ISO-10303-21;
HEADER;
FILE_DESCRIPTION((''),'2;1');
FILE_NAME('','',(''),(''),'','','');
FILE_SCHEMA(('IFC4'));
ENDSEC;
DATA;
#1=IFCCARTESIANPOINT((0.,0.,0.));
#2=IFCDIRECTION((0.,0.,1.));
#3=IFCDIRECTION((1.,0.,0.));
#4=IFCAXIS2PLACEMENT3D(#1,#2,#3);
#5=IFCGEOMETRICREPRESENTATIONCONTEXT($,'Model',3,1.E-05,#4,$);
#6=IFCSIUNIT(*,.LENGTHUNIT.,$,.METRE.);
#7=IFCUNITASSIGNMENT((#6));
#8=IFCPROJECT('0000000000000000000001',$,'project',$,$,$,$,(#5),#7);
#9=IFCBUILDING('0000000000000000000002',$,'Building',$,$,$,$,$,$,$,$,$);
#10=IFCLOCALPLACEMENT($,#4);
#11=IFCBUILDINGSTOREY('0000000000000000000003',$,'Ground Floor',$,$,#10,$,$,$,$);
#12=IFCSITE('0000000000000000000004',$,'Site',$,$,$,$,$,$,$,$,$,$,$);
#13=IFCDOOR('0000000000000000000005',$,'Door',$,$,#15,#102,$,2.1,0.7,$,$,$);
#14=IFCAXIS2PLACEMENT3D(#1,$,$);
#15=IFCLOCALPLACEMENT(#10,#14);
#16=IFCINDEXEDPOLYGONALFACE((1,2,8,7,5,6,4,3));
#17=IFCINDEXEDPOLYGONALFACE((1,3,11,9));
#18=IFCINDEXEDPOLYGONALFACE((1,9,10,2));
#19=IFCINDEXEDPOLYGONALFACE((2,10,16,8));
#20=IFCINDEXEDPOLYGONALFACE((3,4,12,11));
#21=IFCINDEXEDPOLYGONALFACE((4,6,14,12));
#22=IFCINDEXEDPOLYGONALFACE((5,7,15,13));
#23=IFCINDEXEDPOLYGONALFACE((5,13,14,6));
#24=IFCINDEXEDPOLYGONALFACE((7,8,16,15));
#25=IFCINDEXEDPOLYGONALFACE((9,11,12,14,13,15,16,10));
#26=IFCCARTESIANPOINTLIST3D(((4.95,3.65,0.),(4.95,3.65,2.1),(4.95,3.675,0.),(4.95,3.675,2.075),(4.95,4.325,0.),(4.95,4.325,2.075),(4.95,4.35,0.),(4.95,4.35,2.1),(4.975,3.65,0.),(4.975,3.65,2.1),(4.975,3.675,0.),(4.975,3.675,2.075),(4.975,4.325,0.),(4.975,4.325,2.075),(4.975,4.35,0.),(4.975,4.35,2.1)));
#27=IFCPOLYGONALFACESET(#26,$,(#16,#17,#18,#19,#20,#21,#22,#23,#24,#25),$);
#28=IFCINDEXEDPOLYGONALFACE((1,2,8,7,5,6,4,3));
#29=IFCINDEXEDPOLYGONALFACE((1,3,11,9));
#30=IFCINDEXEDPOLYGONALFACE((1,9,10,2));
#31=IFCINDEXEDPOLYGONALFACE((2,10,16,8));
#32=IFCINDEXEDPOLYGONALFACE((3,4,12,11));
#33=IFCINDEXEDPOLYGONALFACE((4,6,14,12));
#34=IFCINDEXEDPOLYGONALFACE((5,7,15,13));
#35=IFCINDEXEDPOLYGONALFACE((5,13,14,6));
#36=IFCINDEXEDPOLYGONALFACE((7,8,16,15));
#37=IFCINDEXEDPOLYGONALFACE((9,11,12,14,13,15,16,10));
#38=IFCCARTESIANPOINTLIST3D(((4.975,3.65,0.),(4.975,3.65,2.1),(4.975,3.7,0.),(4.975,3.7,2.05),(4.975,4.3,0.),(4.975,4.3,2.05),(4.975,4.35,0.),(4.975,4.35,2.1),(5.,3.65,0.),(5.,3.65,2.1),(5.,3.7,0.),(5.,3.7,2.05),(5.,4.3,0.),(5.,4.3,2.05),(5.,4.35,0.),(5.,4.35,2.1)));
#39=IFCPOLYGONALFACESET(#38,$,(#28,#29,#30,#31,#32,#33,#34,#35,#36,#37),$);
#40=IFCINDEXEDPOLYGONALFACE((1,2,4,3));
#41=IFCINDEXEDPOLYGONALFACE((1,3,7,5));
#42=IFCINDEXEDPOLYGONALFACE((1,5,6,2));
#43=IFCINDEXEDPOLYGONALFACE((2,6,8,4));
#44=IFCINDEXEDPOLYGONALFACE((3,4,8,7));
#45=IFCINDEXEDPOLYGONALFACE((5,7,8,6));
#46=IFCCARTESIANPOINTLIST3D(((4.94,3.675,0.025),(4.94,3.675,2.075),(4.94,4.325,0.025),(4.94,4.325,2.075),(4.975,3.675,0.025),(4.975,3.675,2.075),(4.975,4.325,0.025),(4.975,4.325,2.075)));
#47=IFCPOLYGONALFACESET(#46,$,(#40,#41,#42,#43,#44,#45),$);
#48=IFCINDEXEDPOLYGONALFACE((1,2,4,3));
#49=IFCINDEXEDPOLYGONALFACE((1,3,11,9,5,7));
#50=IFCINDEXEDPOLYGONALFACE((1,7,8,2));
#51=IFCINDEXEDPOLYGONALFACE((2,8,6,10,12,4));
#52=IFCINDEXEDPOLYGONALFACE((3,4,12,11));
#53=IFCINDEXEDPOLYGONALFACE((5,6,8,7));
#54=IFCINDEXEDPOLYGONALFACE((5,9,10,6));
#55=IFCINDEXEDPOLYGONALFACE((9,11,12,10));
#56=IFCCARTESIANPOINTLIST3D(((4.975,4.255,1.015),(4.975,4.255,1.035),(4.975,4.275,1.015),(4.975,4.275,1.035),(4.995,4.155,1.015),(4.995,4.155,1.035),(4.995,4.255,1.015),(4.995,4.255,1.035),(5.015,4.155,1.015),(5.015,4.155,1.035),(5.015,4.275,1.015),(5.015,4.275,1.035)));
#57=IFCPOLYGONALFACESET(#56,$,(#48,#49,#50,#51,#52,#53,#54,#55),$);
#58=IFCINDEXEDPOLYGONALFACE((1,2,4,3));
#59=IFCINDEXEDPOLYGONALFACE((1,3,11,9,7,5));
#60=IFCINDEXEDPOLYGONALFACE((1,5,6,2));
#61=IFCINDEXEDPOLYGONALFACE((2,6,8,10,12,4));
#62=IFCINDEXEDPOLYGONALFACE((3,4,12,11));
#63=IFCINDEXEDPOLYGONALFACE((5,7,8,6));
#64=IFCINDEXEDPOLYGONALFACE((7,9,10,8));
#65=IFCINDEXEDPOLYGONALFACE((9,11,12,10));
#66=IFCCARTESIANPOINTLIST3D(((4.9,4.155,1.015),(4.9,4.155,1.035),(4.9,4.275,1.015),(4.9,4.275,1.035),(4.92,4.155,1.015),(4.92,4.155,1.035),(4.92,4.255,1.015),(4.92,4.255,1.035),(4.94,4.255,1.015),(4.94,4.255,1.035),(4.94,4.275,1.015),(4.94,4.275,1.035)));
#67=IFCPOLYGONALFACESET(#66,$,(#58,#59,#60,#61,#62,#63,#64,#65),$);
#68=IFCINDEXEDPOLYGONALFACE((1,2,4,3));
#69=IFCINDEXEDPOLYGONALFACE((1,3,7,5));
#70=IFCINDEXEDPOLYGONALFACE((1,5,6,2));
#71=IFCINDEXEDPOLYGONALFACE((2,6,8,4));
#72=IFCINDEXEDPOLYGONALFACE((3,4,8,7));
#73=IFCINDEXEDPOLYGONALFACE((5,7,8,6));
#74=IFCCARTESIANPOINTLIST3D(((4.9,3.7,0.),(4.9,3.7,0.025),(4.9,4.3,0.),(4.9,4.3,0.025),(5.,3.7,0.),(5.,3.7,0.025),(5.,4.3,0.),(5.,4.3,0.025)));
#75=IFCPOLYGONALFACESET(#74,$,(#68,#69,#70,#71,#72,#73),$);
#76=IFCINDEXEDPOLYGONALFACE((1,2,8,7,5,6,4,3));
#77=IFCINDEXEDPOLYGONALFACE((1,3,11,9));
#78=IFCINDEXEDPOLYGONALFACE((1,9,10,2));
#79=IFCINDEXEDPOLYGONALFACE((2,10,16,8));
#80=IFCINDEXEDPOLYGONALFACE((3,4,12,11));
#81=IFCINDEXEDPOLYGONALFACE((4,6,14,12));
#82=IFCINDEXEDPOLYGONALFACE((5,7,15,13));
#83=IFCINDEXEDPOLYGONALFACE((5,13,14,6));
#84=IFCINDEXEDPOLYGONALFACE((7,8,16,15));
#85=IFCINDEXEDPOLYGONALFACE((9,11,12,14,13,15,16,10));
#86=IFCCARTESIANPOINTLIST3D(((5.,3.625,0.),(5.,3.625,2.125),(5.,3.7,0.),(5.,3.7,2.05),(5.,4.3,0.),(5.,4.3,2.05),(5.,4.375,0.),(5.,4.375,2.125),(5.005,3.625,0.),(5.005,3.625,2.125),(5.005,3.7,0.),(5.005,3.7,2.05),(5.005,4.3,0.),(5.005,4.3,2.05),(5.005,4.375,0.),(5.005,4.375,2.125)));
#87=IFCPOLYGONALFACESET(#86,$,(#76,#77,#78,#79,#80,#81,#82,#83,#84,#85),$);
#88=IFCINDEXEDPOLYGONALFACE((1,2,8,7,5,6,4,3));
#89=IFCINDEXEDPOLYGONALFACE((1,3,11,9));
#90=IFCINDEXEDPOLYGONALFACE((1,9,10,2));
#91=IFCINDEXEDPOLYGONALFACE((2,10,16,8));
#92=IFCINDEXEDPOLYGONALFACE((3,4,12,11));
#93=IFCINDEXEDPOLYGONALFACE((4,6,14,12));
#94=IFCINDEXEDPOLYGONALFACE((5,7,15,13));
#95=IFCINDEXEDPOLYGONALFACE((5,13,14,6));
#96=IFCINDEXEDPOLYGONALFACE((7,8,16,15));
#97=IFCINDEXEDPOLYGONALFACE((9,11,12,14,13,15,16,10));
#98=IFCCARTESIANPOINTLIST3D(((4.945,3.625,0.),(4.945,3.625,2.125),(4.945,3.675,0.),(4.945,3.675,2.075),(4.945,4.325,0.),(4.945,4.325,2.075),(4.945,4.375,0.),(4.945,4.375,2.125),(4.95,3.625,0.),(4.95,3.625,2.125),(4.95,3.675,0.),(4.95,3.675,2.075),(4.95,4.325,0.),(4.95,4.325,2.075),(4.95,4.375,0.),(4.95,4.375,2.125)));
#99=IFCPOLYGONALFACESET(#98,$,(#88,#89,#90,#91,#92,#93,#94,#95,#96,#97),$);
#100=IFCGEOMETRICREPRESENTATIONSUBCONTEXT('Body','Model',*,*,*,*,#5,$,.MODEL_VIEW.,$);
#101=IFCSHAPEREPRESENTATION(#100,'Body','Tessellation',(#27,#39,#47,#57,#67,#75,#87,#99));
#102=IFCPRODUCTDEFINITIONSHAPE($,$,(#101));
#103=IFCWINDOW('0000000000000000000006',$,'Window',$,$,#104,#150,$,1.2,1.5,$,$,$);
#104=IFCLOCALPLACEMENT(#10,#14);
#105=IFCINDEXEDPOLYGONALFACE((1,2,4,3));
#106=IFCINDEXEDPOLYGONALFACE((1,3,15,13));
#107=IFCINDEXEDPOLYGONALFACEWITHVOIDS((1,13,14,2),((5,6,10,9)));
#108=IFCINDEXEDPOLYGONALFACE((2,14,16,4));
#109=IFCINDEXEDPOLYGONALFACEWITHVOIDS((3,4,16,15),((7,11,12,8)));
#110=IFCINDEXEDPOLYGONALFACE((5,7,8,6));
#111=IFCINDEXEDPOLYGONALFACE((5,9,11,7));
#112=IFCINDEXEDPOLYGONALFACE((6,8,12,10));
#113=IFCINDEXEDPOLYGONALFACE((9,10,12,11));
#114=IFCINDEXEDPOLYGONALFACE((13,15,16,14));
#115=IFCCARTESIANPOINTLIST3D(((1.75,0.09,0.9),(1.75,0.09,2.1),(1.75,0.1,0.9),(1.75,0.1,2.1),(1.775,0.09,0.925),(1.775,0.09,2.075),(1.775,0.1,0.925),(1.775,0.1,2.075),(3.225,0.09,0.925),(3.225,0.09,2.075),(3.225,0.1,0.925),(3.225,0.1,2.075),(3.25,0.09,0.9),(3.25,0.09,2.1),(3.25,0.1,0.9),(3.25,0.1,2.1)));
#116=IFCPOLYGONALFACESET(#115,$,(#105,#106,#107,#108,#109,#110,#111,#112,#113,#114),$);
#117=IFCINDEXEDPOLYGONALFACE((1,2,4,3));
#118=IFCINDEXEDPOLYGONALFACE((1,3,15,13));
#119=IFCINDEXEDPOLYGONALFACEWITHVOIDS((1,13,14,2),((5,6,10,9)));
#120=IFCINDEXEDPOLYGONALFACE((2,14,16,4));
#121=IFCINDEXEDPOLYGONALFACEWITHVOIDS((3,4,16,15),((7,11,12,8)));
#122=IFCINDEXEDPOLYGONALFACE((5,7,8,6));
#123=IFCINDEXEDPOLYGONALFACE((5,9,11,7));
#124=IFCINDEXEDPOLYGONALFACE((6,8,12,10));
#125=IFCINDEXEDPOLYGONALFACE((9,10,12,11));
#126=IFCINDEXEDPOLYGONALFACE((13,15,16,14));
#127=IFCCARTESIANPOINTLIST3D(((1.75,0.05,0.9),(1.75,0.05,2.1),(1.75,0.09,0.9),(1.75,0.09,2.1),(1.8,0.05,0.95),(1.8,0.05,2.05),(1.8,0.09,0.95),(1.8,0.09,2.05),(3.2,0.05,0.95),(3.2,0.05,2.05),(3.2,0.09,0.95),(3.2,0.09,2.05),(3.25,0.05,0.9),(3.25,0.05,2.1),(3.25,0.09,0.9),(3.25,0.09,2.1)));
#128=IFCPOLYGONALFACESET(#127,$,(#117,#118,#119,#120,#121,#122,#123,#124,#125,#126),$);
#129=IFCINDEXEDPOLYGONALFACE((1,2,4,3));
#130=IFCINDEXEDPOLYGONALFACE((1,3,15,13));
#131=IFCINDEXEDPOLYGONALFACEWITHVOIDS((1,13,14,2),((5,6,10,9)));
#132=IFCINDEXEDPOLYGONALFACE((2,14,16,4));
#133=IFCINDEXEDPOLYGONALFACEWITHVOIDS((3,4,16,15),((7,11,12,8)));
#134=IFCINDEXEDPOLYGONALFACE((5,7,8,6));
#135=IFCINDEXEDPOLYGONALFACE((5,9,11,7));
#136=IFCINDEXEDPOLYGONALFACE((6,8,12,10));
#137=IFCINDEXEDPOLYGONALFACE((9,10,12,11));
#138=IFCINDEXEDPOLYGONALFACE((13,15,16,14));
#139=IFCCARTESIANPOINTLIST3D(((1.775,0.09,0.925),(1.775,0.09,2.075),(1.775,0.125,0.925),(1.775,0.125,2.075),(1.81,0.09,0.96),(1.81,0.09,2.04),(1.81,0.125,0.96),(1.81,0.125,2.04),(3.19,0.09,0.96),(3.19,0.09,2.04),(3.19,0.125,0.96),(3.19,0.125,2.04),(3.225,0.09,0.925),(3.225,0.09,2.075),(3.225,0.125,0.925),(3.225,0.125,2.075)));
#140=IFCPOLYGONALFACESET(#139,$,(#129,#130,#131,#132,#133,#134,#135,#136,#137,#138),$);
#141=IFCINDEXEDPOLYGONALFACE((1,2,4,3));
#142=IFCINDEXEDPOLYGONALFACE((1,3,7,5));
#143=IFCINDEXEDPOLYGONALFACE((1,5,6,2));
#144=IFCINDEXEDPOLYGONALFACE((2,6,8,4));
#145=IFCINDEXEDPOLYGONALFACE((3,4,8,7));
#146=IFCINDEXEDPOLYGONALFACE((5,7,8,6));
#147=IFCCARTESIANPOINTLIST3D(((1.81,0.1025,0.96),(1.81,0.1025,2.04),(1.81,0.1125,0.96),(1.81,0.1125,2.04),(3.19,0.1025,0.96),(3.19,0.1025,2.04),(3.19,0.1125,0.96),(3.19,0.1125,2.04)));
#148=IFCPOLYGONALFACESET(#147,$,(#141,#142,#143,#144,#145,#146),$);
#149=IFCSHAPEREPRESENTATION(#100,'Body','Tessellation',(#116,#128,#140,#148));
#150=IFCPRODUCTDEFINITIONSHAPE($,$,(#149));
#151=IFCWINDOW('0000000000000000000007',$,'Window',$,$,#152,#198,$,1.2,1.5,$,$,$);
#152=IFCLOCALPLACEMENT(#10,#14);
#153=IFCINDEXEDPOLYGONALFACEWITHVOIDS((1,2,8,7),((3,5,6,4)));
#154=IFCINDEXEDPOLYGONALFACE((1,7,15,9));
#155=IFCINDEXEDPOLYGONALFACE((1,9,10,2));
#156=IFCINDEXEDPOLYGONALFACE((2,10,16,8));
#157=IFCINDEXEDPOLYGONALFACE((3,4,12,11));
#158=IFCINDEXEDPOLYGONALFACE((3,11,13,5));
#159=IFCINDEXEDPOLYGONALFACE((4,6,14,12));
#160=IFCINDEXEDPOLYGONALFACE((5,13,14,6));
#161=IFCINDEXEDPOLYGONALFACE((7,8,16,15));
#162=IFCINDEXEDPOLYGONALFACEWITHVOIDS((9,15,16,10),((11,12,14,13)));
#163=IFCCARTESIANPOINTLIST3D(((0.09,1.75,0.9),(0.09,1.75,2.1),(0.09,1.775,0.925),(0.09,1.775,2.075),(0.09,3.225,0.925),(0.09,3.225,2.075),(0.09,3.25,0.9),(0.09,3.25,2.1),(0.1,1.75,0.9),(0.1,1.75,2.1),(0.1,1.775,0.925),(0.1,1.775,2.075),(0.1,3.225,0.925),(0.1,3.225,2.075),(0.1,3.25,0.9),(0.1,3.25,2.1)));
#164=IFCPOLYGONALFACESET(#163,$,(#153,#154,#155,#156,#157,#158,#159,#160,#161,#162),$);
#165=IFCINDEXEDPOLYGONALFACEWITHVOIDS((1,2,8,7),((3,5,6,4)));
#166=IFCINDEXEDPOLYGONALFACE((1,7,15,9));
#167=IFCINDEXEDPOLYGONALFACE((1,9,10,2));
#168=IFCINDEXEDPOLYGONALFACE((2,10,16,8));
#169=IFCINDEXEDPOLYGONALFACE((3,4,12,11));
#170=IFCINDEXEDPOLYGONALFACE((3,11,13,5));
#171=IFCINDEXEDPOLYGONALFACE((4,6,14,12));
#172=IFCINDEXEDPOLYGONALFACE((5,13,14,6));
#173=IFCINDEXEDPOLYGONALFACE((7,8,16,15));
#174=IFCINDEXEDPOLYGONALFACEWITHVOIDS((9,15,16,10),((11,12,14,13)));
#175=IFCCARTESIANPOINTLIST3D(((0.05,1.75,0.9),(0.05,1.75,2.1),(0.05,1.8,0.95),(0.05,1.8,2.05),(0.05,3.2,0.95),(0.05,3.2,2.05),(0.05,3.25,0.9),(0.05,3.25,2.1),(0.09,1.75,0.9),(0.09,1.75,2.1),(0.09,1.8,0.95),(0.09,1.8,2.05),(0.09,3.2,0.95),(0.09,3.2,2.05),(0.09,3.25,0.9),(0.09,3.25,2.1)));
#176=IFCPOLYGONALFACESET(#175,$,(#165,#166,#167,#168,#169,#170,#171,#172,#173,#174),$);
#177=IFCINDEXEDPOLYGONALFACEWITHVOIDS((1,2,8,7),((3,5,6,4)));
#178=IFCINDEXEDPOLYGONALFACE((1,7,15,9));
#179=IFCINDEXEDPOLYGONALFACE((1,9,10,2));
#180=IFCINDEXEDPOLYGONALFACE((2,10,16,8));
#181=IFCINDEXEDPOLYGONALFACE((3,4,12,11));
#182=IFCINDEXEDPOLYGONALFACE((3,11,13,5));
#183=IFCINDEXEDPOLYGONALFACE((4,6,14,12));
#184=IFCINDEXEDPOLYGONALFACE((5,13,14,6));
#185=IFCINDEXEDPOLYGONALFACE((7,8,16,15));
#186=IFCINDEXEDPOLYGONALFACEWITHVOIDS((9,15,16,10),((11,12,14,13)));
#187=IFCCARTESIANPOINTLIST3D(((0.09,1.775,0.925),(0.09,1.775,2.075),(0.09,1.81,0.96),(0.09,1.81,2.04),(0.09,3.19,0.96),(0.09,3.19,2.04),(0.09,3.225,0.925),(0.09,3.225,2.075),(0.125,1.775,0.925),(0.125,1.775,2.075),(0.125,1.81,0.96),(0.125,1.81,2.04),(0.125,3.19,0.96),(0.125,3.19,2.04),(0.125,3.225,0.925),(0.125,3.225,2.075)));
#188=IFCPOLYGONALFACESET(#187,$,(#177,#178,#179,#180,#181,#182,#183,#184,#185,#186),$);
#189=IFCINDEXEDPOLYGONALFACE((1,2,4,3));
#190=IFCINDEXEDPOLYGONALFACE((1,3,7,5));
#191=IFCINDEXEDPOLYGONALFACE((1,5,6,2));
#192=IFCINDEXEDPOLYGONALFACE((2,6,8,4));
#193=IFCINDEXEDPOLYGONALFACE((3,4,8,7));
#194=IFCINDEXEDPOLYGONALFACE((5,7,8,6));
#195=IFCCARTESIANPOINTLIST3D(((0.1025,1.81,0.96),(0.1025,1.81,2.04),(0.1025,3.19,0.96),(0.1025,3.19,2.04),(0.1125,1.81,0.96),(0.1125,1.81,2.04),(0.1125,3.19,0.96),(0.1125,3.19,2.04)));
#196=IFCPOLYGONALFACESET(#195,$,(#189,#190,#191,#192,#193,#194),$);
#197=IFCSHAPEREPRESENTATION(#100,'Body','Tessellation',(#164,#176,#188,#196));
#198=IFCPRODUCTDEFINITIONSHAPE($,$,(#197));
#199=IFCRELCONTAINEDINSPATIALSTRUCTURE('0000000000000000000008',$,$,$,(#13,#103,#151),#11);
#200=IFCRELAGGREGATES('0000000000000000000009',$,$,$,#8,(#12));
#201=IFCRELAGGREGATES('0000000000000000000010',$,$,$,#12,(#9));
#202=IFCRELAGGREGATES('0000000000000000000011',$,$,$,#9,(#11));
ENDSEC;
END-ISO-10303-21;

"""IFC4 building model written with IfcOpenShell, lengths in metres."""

from ifc_helpers import new_model, si_unit, frame, origin_with_axes, place, context, subcontext, project, spatial, line, indexed_curve, outline, extrude, element, save


model = new_model("IFC4")

# Units and contexts
model_context = context("Model", 3, precision=1e-05, world=origin_with_axes())
body_context = subcontext(model_context, "Body", "Model", "MODEL_VIEW")
ifc_project = project(units=[si_unit("LENGTHUNIT", "METRE")], contexts=[model_context])

# Site, building, storey
site = spatial("IfcSite", under=ifc_project, Name="Site")
building = spatial("IfcBuilding", under=site, Name="Building")
storey_placement = place(None, origin_with_axes())
storey = spatial("IfcBuildingStorey", under=building, at=storey_placement, Name="Ground Floor")

# Door
door_1_placement = place(storey_placement, frame((5.0, 3.65, 0.0), z_axis=(0.0, 0.0, 1.0), x_axis=(0.0, 1.0, 0.0)))
element("IfcDoor", 1, at=door_1_placement, inside=storey, Name="Door", OverallHeight=2.1, OverallWidth=0.7, context=body_context, shape_type="SweptSolid", body=[
    extrude(outline(indexed_curve([(0.0, 0.0), (0.0, 2.1), (0.7, 2.1), (0.7, 0.0), (0.675, 0.0), (0.675, 2.075), (0.025, 2.075), (0.025, 0.0)], segments=[line(1, 2, 3, 4, 5, 6, 7, 8, 1)])), frame((0.0, 0.025, 0.0), z_axis=(0.0, -1.0, 0.0), x_axis=(1.0, 0.0, 0.0)), (0.0, 0.0, -1.0), 0.025),
    extrude(outline(indexed_curve([(0.0, 0.0), (0.0, 2.1), (0.7, 2.1), (0.7, 0.0), (0.65, 0.0), (0.65, 2.05), (0.05, 2.05), (0.05, 0.0)], segments=[line(1, 2, 3, 4, 5, 6, 7, 8, 1)])), frame((0.0, 0.0, 0.0), z_axis=(0.0, -1.0, 0.0), x_axis=(1.0, 0.0, 0.0)), (0.0, 0.0, -1.0), 0.025),
    extrude(outline(indexed_curve([(0.0, 0.0), (0.65, 0.0), (0.65, 0.035), (0.0, 0.035)], segments=[line(1, 2, 3, 4, 1)])), frame((0.025, 0.025, 0.025), z_axis=(0.0, 0.0, 1.0), x_axis=(1.0, 0.0, 0.0)), (0.0, 0.0, 1.0), 2.05),
    extrude(outline(indexed_curve([(0.0, 0.0), (0.0, -0.04), (-0.12, -0.04), (-0.12, -0.02), (-0.02, -0.02), (-0.02, 0.0)], segments=[line(1, 2, 3, 4, 5, 6, 1)])), frame((0.625, 0.025, 1.015), z_axis=(0.0, 0.0, 1.0), x_axis=(1.0, 0.0, 0.0)), (0.0, 0.0, 1.0), 0.02),
    extrude(outline(indexed_curve([(0.0, 0.0), (0.0, 0.04), (-0.12, 0.04), (-0.12, 0.02), (-0.02, 0.02), (-0.02, 0.0)], segments=[line(1, 2, 3, 4, 5, 6, 1)])), frame((0.625, 0.06, 1.015), z_axis=(0.0, 0.0, 1.0), x_axis=(1.0, 0.0, 0.0)), (0.0, 0.0, 1.0), 0.02),
    extrude(outline(indexed_curve([(0.0, 0.0), (0.6, 0.0), (0.6, 0.1), (0.0, 0.1)], segments=[line(1, 2, 3, 4, 1)])), frame((0.05, 0.0, 0.0), z_axis=(0.0, 0.0, 1.0), x_axis=(1.0, 0.0, 0.0)), (0.0, 0.0, 1.0), 0.025),
    extrude(outline(indexed_curve([(0.0, 0.0), (0.0, 2.125), (0.75, 2.125), (0.75, 0.0), (0.675, 0.0), (0.675, 2.05), (0.075, 2.05), (0.075, 0.0)], segments=[line(1, 2, 3, 4, 5, 6, 7, 8, 1)])), frame((-0.025, -0.005, 0.0), z_axis=(0.0, -1.0, 0.0), x_axis=(1.0, 0.0, 0.0)), (0.0, 0.0, -1.0), 0.005),
    extrude(outline(indexed_curve([(0.0, 0.0), (0.0, 2.125), (0.75, 2.125), (0.75, 0.0), (0.7, 0.0), (0.7, 2.075), (0.05, 2.075), (0.05, 0.0)], segments=[line(1, 2, 3, 4, 5, 6, 7, 8, 1)])), frame((-0.025, 0.05, 0.0), z_axis=(0.0, -1.0, 0.0), x_axis=(1.0, 0.0, 0.0)), (0.0, 0.0, -1.0), 0.005),
])

# Windows
for number, where, z_axis, x_axis, name in (
    (2, (1.75, 0.0, 0.9), (0.0, 0.0, 1.0), (1.0, 0.0, 0.0), "Window"),
    (3, (0.0, 3.25, 0.9), (0.0, 0.0, 1.0), (0.0, -1.0, 0.0), "Window"),
):
    element("IfcWindow", number, at=place(storey_placement, frame(where, z_axis=z_axis, x_axis=x_axis)), inside=storey, Name=name, OverallHeight=1.2, OverallWidth=1.5, context=body_context, shape_type="SweptSolid", body=[
        extrude(outline(indexed_curve([(0.0, 0.0), (1.5, 0.0), (1.5, 1.2), (0.0, 1.2)], segments=[line(1, 2, 3, 4, 1)]), holes=[indexed_curve([(0.025, 0.025), (1.475, 0.025), (1.475, 1.175), (0.025, 1.175)], segments=[line(1, 2, 3, 4, 1)])]), frame((0.0, 0.09, 0.0), z_axis=(0.0, -1.0, 0.0), x_axis=(1.0, 0.0, 0.0)), (0.0, 0.0, -1.0), 0.01),
        extrude(outline(indexed_curve([(0.0, 0.0), (1.5, 0.0), (1.5, 1.2), (0.0, 1.2)], segments=[line(1, 2, 3, 4, 1)]), holes=[indexed_curve([(0.05, 0.05), (1.45, 0.05), (1.45, 1.15), (0.05, 1.15)], segments=[line(1, 2, 3, 4, 1)])]), frame((0.0, 0.05, 0.0), z_axis=(0.0, -1.0, 0.0), x_axis=(1.0, 0.0, 0.0)), (0.0, 0.0, -1.0), 0.04),
        extrude(outline(indexed_curve([(0.0, 0.0), (1.45, 0.0), (1.45, 1.15), (0.0, 1.15)], segments=[line(1, 2, 3, 4, 1)]), holes=[indexed_curve([(0.035, 0.035), (1.415, 0.035), (1.415, 1.115), (0.035, 1.115)], segments=[line(1, 2, 3, 4, 1)])]), frame((0.025, 0.09, 0.025), z_axis=(0.0, -1.0, 0.0), x_axis=(1.0, 0.0, 0.0)), (0.0, 0.0, -1.0), 0.035),
        extrude(outline(indexed_curve([(0.035, 0.035), (1.415, 0.035), (1.415, 1.115), (0.035, 1.115)], segments=[line(1, 2, 3, 4, 1)])), frame((0.025, 0.1025, 0.025), z_axis=(0.0, -1.0, 0.0), x_axis=(1.0, 0.0, 0.0)), (0.0, 0.0, -1.0), 0.01),
    ])

save(model, "model.ifc")
